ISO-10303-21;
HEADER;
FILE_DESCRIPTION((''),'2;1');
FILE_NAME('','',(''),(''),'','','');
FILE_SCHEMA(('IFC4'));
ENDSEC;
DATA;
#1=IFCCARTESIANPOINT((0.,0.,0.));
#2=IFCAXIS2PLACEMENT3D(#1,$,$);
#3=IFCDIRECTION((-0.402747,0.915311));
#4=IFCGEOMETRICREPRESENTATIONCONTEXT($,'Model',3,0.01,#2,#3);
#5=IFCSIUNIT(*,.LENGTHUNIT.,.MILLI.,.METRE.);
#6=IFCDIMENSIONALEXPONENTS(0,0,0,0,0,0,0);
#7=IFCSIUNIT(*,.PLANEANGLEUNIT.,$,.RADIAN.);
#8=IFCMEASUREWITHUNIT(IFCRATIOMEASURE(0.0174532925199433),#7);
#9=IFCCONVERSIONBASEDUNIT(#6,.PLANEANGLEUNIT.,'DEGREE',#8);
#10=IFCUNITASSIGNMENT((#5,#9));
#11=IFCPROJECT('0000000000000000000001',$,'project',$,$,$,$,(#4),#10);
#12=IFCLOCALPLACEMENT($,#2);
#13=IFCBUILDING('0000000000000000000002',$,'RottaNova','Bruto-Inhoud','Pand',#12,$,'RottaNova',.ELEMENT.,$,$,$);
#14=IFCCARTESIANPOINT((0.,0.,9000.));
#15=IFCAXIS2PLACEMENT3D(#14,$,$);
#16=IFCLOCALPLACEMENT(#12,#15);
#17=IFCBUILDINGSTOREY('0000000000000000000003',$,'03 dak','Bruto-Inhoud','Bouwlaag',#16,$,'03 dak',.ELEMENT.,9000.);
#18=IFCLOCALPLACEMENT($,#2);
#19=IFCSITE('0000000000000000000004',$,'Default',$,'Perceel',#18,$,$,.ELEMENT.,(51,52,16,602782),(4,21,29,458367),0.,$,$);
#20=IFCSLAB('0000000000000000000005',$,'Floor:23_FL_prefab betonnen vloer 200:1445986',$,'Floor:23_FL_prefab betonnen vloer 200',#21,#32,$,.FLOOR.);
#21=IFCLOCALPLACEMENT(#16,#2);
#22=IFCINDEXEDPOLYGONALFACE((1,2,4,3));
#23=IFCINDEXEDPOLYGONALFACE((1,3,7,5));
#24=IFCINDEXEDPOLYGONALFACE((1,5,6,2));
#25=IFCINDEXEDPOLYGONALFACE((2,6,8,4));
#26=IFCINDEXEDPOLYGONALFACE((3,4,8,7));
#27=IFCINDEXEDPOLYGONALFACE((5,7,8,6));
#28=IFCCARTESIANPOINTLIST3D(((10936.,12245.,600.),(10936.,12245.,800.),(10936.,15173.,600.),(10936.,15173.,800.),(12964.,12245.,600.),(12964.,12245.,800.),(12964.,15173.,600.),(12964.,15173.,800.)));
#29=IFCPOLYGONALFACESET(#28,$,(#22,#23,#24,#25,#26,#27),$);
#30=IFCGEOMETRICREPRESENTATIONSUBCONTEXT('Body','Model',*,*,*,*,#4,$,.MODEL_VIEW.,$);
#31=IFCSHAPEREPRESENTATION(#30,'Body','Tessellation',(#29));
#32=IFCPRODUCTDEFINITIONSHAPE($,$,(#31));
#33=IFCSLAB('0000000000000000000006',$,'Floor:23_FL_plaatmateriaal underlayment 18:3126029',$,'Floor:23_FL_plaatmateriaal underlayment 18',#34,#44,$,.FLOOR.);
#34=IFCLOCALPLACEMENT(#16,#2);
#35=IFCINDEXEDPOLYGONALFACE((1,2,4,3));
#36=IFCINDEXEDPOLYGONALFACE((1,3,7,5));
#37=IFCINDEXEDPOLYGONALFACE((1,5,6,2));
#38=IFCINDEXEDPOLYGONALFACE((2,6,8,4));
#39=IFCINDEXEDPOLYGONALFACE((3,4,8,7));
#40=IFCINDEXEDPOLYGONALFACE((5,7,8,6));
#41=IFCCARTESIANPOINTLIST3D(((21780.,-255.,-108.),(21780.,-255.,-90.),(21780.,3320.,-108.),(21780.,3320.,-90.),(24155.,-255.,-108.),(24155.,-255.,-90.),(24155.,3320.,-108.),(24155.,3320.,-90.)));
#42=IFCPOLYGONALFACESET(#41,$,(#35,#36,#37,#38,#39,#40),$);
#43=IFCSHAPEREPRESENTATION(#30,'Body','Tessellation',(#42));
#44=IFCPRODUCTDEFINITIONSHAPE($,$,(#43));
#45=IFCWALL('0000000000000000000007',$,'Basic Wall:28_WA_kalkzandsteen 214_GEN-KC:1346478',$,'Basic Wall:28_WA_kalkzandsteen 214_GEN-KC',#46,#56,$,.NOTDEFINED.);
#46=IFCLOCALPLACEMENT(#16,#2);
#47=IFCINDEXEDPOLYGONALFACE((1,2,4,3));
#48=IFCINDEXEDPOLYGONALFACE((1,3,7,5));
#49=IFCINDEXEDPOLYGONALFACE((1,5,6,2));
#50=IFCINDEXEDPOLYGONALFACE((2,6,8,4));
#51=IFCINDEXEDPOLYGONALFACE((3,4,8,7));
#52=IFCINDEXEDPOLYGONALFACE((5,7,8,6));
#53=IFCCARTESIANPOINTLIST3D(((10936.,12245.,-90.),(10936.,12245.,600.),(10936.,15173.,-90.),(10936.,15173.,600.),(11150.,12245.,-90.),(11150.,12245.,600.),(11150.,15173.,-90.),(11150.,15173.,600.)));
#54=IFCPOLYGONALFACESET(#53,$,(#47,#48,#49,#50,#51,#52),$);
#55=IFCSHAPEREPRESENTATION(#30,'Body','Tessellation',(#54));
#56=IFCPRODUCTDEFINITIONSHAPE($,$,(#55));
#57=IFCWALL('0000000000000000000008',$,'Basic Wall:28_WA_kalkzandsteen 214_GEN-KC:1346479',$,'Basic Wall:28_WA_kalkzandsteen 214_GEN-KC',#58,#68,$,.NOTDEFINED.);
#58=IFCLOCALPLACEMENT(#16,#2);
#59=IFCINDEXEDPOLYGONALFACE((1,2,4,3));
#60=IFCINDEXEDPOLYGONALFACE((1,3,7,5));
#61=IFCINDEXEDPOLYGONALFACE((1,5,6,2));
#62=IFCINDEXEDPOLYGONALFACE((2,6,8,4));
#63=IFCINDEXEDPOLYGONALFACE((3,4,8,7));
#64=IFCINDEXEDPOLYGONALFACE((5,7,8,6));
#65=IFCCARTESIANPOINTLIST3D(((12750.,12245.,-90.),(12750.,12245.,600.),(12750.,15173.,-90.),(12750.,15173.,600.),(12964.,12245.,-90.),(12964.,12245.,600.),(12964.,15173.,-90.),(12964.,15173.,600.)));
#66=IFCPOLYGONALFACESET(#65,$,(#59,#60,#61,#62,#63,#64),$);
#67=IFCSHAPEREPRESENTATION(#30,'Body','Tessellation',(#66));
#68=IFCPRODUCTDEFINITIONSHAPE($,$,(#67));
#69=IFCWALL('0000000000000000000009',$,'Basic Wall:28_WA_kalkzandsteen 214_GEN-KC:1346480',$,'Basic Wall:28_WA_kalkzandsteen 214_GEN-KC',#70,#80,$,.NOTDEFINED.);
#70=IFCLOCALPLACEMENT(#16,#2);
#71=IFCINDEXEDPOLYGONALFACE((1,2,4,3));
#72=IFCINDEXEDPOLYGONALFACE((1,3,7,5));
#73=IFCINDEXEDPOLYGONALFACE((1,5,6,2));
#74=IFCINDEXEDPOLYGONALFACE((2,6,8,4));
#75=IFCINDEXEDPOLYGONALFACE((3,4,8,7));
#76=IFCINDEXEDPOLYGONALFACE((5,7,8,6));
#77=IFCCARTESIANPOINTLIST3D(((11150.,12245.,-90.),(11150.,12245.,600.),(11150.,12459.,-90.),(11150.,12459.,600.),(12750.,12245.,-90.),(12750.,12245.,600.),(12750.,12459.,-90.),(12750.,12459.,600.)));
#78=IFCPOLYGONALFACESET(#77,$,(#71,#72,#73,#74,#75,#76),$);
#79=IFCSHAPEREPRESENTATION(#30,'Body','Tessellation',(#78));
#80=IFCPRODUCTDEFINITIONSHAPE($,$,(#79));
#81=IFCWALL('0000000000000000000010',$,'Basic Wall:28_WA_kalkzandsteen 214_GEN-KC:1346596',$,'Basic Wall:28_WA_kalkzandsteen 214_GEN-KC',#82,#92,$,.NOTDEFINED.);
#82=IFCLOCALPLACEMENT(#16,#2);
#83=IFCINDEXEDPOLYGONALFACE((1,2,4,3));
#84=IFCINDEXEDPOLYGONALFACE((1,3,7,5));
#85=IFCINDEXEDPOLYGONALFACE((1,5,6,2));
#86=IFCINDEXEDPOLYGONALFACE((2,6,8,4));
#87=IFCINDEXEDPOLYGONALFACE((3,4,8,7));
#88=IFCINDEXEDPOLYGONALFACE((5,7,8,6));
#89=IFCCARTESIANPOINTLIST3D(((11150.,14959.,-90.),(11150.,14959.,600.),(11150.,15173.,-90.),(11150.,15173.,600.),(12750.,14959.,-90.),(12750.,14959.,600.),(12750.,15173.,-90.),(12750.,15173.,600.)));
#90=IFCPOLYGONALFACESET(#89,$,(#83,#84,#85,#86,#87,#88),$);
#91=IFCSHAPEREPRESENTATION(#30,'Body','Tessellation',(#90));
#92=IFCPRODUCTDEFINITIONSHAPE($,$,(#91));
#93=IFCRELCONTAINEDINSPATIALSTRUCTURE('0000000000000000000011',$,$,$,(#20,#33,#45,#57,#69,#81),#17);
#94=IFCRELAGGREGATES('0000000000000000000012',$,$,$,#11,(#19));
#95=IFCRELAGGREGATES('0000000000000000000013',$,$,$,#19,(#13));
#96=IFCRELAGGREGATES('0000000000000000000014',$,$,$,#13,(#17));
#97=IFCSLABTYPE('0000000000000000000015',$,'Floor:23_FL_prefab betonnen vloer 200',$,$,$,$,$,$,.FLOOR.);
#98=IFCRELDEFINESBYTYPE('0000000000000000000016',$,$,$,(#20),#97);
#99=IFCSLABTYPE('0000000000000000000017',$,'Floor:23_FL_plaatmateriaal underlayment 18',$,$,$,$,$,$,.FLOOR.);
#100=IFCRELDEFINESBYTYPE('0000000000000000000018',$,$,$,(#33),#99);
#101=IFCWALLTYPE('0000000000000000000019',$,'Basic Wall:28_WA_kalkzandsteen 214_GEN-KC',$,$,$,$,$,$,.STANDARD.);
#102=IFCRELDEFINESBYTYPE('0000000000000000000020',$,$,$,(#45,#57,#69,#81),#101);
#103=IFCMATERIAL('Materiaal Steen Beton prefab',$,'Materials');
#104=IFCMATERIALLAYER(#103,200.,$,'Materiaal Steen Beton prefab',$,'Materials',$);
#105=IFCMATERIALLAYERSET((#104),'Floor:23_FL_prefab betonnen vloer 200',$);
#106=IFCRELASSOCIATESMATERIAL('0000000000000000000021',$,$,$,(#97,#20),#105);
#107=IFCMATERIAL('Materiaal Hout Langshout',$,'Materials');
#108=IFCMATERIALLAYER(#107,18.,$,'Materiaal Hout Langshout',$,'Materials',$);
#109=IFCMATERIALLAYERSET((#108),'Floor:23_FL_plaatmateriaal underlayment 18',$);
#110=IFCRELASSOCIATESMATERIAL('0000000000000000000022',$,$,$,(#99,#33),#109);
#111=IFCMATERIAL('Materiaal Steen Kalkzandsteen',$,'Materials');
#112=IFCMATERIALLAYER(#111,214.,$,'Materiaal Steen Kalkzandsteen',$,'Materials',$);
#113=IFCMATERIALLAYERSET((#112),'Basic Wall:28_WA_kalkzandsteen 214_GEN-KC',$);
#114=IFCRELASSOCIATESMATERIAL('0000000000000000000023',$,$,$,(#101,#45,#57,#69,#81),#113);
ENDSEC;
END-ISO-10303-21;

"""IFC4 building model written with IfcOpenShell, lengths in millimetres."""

from ifc_helpers import new_model, entity, si_unit, converted_unit, direction, frame, frame_2d, origin, place, context, subcontext, project, spatial, rectangle, extrude, material, layer, layer_set, layer_usage, type_object, element, save


model = new_model("IFC4")

# Units and contexts
model_context = context("Model", 3, precision=0.01, world=origin(), true_north=direction((-0.402747, 0.915311)))
body_context = subcontext(model_context, "Body", "Model", "MODEL_VIEW")
ifc_project = project(units=[si_unit("LENGTHUNIT", "METRE", prefix="MILLI"), converted_unit("PLANEANGLEUNIT", "DEGREE", entity("IfcRatioMeasure", 0.0174532925199433), si_unit("PLANEANGLEUNIT", "RADIAN"), dimensions=[0, 0, 0, 0, 0, 0, 0])], contexts=[model_context])

# Site, building, storey
site_placement = place(None, origin())
site = spatial("IfcSite", under=ifc_project, at=site_placement, Name="Default", ObjectType="Perceel", CompositionType="ELEMENT", RefLatitude=(51, 52, 16, 602782), RefLongitude=(4, 21, 29, 458367), RefElevation=0.0)
building_placement = place(None, origin())
building = spatial("IfcBuilding", under=site, at=building_placement, Name="RottaNova", Description="Bruto-Inhoud", ObjectType="Pand", LongName="RottaNova", CompositionType="ELEMENT")
storey_placement = place(building_placement, frame((0.0, 0.0, 9000.0)))
storey = spatial("IfcBuildingStorey", under=building, at=storey_placement, Name="03 dak", Description="Bruto-Inhoud", ObjectType="Bouwlaag", LongName="03 dak", CompositionType="ELEMENT", Elevation=9000.0)

# Slabs
ifc_material_1 = material(Name="Materiaal Steen Beton prefab", Category="Materials")
ifc_layer_1 = layer(ifc_material_1, 200.0, Name="Materiaal Steen Beton prefab", Category="Materials")
ifc_layer_set_1 = layer_set([ifc_layer_1], Name="Floor:23_FL_prefab betonnen vloer 200")
ifc_layer_usage_1 = layer_usage(ifc_layer_set_1, "AXIS3", "POSITIVE", 0.0)
slab_type_1 = type_object("IfcSlabType", Name="Floor:23_FL_prefab betonnen vloer 200", PredefinedType="FLOOR", material=ifc_layer_set_1)
slab_1_placement = place(storey_placement, origin())
element("IfcSlab", 1, at=slab_1_placement, inside=storey, type_object=slab_type_1, material=ifc_layer_usage_1, Name="Floor:23_FL_prefab betonnen vloer 200:1445986", ObjectType="Floor:23_FL_prefab betonnen vloer 200", PredefinedType="FLOOR", context=body_context, shape_type="SweptSolid", body=[
    extrude(rectangle(XDim=2928.0, YDim=2028.0, at=frame_2d((0.0, 0.0), x_axis=(1.0, 0.0))), frame((11950.0, 13709.0, 800.0), z_axis=(0.0, 0.0, -1.0), x_axis=(0.0, 1.0, 0.0)), (0.0, 0.0, 1.0), 200.0),
])
ifc_material_2 = material(Name="Materiaal Hout Langshout", Category="Materials")
ifc_layer_2 = layer(ifc_material_2, 18.0, Name="Materiaal Hout Langshout", Category="Materials")
ifc_layer_set_2 = layer_set([ifc_layer_2], Name="Floor:23_FL_plaatmateriaal underlayment 18")
ifc_layer_usage_2 = layer_usage(ifc_layer_set_2, "AXIS3", "POSITIVE", 0.0)
slab_type_2 = type_object("IfcSlabType", Name="Floor:23_FL_plaatmateriaal underlayment 18", PredefinedType="FLOOR", material=ifc_layer_set_2)
slab_2_placement = place(storey_placement, frame((21780.0, -255.0, -108.0)))
element("IfcSlab", 2, at=slab_2_placement, inside=storey, type_object=slab_type_2, material=ifc_layer_usage_2, Name="Floor:23_FL_plaatmateriaal underlayment 18:3126029", ObjectType="Floor:23_FL_plaatmateriaal underlayment 18", PredefinedType="FLOOR", context=body_context, shape_type="SweptSolid", body=[
    extrude(rectangle(XDim=2375.0, YDim=3575.0, at=frame_2d((0.0, -12542.5), x_axis=(1.0, 0.0))), frame((1187.5, 14330.0, 18.0), z_axis=(0.0, 0.0, -1.0), x_axis=(-1.0, 0.0, 0.0)), (0.0, 0.0, 1.0), 18.0),
])

# Walls
ifc_material_3 = material(Name="Materiaal Steen Kalkzandsteen", Category="Materials")
ifc_layer_3 = layer(ifc_material_3, 214.0, Name="Materiaal Steen Kalkzandsteen", Category="Materials")
ifc_layer_set_3 = layer_set([ifc_layer_3], Name="Basic Wall:28_WA_kalkzandsteen 214_GEN-KC")
wall_type = type_object("IfcWallType", Name="Basic Wall:28_WA_kalkzandsteen 214_GEN-KC", PredefinedType="STANDARD", material=ifc_layer_set_3)
wall_1_placement = place(storey_placement, frame((11043.0, 12245.0, -90.0), z_axis=(0.0, 0.0, 1.0), x_axis=(0.0, 1.0, 0.0)))
element("IfcWall", 3, at=wall_1_placement, inside=storey, type_object=wall_type, material=ifc_layer_set_3, Name="Basic Wall:28_WA_kalkzandsteen 214_GEN-KC:1346478", ObjectType="Basic Wall:28_WA_kalkzandsteen 214_GEN-KC", PredefinedType="NOTDEFINED", context=body_context, shape_type="SweptSolid", body=[
    extrude(rectangle(XDim=2928.0, YDim=214.0, at=frame_2d((1464.0, 0.0), x_axis=(-1.0, 0.0))), origin(), (0.0, 0.0, 1.0), 690.0),
])
wall_2_placement = place(storey_placement, frame((12857.0, 12245.0, -90.0), z_axis=(0.0, 0.0, 1.0), x_axis=(0.0, 1.0, 0.0)))
element("IfcWall", 4, at=wall_2_placement, inside=storey, type_object=wall_type, material=ifc_layer_set_3, Name="Basic Wall:28_WA_kalkzandsteen 214_GEN-KC:1346479", ObjectType="Basic Wall:28_WA_kalkzandsteen 214_GEN-KC", PredefinedType="NOTDEFINED", context=body_context, shape_type="SweptSolid", body=[
    extrude(rectangle(XDim=2928.0, YDim=214.0, at=frame_2d((1464.0, 0.0), x_axis=(-1.0, 0.0))), origin(), (0.0, 0.0, 1.0), 690.0),
])
for number, where, name in (
    (5, (11150.0, 12352.0, -90.0), "Basic Wall:28_WA_kalkzandsteen 214_GEN-KC:1346480"),
    (6, (11150.0, 15066.0, -90.0), "Basic Wall:28_WA_kalkzandsteen 214_GEN-KC:1346596"),
):
    element("IfcWall", number, at=place(storey_placement, frame(where)), inside=storey, type_object=wall_type, material=ifc_layer_set_3, Name=name, ObjectType="Basic Wall:28_WA_kalkzandsteen 214_GEN-KC", PredefinedType="NOTDEFINED", context=body_context, shape_type="SweptSolid", body=[
        extrude(rectangle(XDim=1600.0, YDim=214.0, at=frame_2d((800.0, 0.0), x_axis=(-1.0, 0.0))), origin(), (0.0, 0.0, 1.0), 690.0),
    ])

save(model, "model.ifc")
